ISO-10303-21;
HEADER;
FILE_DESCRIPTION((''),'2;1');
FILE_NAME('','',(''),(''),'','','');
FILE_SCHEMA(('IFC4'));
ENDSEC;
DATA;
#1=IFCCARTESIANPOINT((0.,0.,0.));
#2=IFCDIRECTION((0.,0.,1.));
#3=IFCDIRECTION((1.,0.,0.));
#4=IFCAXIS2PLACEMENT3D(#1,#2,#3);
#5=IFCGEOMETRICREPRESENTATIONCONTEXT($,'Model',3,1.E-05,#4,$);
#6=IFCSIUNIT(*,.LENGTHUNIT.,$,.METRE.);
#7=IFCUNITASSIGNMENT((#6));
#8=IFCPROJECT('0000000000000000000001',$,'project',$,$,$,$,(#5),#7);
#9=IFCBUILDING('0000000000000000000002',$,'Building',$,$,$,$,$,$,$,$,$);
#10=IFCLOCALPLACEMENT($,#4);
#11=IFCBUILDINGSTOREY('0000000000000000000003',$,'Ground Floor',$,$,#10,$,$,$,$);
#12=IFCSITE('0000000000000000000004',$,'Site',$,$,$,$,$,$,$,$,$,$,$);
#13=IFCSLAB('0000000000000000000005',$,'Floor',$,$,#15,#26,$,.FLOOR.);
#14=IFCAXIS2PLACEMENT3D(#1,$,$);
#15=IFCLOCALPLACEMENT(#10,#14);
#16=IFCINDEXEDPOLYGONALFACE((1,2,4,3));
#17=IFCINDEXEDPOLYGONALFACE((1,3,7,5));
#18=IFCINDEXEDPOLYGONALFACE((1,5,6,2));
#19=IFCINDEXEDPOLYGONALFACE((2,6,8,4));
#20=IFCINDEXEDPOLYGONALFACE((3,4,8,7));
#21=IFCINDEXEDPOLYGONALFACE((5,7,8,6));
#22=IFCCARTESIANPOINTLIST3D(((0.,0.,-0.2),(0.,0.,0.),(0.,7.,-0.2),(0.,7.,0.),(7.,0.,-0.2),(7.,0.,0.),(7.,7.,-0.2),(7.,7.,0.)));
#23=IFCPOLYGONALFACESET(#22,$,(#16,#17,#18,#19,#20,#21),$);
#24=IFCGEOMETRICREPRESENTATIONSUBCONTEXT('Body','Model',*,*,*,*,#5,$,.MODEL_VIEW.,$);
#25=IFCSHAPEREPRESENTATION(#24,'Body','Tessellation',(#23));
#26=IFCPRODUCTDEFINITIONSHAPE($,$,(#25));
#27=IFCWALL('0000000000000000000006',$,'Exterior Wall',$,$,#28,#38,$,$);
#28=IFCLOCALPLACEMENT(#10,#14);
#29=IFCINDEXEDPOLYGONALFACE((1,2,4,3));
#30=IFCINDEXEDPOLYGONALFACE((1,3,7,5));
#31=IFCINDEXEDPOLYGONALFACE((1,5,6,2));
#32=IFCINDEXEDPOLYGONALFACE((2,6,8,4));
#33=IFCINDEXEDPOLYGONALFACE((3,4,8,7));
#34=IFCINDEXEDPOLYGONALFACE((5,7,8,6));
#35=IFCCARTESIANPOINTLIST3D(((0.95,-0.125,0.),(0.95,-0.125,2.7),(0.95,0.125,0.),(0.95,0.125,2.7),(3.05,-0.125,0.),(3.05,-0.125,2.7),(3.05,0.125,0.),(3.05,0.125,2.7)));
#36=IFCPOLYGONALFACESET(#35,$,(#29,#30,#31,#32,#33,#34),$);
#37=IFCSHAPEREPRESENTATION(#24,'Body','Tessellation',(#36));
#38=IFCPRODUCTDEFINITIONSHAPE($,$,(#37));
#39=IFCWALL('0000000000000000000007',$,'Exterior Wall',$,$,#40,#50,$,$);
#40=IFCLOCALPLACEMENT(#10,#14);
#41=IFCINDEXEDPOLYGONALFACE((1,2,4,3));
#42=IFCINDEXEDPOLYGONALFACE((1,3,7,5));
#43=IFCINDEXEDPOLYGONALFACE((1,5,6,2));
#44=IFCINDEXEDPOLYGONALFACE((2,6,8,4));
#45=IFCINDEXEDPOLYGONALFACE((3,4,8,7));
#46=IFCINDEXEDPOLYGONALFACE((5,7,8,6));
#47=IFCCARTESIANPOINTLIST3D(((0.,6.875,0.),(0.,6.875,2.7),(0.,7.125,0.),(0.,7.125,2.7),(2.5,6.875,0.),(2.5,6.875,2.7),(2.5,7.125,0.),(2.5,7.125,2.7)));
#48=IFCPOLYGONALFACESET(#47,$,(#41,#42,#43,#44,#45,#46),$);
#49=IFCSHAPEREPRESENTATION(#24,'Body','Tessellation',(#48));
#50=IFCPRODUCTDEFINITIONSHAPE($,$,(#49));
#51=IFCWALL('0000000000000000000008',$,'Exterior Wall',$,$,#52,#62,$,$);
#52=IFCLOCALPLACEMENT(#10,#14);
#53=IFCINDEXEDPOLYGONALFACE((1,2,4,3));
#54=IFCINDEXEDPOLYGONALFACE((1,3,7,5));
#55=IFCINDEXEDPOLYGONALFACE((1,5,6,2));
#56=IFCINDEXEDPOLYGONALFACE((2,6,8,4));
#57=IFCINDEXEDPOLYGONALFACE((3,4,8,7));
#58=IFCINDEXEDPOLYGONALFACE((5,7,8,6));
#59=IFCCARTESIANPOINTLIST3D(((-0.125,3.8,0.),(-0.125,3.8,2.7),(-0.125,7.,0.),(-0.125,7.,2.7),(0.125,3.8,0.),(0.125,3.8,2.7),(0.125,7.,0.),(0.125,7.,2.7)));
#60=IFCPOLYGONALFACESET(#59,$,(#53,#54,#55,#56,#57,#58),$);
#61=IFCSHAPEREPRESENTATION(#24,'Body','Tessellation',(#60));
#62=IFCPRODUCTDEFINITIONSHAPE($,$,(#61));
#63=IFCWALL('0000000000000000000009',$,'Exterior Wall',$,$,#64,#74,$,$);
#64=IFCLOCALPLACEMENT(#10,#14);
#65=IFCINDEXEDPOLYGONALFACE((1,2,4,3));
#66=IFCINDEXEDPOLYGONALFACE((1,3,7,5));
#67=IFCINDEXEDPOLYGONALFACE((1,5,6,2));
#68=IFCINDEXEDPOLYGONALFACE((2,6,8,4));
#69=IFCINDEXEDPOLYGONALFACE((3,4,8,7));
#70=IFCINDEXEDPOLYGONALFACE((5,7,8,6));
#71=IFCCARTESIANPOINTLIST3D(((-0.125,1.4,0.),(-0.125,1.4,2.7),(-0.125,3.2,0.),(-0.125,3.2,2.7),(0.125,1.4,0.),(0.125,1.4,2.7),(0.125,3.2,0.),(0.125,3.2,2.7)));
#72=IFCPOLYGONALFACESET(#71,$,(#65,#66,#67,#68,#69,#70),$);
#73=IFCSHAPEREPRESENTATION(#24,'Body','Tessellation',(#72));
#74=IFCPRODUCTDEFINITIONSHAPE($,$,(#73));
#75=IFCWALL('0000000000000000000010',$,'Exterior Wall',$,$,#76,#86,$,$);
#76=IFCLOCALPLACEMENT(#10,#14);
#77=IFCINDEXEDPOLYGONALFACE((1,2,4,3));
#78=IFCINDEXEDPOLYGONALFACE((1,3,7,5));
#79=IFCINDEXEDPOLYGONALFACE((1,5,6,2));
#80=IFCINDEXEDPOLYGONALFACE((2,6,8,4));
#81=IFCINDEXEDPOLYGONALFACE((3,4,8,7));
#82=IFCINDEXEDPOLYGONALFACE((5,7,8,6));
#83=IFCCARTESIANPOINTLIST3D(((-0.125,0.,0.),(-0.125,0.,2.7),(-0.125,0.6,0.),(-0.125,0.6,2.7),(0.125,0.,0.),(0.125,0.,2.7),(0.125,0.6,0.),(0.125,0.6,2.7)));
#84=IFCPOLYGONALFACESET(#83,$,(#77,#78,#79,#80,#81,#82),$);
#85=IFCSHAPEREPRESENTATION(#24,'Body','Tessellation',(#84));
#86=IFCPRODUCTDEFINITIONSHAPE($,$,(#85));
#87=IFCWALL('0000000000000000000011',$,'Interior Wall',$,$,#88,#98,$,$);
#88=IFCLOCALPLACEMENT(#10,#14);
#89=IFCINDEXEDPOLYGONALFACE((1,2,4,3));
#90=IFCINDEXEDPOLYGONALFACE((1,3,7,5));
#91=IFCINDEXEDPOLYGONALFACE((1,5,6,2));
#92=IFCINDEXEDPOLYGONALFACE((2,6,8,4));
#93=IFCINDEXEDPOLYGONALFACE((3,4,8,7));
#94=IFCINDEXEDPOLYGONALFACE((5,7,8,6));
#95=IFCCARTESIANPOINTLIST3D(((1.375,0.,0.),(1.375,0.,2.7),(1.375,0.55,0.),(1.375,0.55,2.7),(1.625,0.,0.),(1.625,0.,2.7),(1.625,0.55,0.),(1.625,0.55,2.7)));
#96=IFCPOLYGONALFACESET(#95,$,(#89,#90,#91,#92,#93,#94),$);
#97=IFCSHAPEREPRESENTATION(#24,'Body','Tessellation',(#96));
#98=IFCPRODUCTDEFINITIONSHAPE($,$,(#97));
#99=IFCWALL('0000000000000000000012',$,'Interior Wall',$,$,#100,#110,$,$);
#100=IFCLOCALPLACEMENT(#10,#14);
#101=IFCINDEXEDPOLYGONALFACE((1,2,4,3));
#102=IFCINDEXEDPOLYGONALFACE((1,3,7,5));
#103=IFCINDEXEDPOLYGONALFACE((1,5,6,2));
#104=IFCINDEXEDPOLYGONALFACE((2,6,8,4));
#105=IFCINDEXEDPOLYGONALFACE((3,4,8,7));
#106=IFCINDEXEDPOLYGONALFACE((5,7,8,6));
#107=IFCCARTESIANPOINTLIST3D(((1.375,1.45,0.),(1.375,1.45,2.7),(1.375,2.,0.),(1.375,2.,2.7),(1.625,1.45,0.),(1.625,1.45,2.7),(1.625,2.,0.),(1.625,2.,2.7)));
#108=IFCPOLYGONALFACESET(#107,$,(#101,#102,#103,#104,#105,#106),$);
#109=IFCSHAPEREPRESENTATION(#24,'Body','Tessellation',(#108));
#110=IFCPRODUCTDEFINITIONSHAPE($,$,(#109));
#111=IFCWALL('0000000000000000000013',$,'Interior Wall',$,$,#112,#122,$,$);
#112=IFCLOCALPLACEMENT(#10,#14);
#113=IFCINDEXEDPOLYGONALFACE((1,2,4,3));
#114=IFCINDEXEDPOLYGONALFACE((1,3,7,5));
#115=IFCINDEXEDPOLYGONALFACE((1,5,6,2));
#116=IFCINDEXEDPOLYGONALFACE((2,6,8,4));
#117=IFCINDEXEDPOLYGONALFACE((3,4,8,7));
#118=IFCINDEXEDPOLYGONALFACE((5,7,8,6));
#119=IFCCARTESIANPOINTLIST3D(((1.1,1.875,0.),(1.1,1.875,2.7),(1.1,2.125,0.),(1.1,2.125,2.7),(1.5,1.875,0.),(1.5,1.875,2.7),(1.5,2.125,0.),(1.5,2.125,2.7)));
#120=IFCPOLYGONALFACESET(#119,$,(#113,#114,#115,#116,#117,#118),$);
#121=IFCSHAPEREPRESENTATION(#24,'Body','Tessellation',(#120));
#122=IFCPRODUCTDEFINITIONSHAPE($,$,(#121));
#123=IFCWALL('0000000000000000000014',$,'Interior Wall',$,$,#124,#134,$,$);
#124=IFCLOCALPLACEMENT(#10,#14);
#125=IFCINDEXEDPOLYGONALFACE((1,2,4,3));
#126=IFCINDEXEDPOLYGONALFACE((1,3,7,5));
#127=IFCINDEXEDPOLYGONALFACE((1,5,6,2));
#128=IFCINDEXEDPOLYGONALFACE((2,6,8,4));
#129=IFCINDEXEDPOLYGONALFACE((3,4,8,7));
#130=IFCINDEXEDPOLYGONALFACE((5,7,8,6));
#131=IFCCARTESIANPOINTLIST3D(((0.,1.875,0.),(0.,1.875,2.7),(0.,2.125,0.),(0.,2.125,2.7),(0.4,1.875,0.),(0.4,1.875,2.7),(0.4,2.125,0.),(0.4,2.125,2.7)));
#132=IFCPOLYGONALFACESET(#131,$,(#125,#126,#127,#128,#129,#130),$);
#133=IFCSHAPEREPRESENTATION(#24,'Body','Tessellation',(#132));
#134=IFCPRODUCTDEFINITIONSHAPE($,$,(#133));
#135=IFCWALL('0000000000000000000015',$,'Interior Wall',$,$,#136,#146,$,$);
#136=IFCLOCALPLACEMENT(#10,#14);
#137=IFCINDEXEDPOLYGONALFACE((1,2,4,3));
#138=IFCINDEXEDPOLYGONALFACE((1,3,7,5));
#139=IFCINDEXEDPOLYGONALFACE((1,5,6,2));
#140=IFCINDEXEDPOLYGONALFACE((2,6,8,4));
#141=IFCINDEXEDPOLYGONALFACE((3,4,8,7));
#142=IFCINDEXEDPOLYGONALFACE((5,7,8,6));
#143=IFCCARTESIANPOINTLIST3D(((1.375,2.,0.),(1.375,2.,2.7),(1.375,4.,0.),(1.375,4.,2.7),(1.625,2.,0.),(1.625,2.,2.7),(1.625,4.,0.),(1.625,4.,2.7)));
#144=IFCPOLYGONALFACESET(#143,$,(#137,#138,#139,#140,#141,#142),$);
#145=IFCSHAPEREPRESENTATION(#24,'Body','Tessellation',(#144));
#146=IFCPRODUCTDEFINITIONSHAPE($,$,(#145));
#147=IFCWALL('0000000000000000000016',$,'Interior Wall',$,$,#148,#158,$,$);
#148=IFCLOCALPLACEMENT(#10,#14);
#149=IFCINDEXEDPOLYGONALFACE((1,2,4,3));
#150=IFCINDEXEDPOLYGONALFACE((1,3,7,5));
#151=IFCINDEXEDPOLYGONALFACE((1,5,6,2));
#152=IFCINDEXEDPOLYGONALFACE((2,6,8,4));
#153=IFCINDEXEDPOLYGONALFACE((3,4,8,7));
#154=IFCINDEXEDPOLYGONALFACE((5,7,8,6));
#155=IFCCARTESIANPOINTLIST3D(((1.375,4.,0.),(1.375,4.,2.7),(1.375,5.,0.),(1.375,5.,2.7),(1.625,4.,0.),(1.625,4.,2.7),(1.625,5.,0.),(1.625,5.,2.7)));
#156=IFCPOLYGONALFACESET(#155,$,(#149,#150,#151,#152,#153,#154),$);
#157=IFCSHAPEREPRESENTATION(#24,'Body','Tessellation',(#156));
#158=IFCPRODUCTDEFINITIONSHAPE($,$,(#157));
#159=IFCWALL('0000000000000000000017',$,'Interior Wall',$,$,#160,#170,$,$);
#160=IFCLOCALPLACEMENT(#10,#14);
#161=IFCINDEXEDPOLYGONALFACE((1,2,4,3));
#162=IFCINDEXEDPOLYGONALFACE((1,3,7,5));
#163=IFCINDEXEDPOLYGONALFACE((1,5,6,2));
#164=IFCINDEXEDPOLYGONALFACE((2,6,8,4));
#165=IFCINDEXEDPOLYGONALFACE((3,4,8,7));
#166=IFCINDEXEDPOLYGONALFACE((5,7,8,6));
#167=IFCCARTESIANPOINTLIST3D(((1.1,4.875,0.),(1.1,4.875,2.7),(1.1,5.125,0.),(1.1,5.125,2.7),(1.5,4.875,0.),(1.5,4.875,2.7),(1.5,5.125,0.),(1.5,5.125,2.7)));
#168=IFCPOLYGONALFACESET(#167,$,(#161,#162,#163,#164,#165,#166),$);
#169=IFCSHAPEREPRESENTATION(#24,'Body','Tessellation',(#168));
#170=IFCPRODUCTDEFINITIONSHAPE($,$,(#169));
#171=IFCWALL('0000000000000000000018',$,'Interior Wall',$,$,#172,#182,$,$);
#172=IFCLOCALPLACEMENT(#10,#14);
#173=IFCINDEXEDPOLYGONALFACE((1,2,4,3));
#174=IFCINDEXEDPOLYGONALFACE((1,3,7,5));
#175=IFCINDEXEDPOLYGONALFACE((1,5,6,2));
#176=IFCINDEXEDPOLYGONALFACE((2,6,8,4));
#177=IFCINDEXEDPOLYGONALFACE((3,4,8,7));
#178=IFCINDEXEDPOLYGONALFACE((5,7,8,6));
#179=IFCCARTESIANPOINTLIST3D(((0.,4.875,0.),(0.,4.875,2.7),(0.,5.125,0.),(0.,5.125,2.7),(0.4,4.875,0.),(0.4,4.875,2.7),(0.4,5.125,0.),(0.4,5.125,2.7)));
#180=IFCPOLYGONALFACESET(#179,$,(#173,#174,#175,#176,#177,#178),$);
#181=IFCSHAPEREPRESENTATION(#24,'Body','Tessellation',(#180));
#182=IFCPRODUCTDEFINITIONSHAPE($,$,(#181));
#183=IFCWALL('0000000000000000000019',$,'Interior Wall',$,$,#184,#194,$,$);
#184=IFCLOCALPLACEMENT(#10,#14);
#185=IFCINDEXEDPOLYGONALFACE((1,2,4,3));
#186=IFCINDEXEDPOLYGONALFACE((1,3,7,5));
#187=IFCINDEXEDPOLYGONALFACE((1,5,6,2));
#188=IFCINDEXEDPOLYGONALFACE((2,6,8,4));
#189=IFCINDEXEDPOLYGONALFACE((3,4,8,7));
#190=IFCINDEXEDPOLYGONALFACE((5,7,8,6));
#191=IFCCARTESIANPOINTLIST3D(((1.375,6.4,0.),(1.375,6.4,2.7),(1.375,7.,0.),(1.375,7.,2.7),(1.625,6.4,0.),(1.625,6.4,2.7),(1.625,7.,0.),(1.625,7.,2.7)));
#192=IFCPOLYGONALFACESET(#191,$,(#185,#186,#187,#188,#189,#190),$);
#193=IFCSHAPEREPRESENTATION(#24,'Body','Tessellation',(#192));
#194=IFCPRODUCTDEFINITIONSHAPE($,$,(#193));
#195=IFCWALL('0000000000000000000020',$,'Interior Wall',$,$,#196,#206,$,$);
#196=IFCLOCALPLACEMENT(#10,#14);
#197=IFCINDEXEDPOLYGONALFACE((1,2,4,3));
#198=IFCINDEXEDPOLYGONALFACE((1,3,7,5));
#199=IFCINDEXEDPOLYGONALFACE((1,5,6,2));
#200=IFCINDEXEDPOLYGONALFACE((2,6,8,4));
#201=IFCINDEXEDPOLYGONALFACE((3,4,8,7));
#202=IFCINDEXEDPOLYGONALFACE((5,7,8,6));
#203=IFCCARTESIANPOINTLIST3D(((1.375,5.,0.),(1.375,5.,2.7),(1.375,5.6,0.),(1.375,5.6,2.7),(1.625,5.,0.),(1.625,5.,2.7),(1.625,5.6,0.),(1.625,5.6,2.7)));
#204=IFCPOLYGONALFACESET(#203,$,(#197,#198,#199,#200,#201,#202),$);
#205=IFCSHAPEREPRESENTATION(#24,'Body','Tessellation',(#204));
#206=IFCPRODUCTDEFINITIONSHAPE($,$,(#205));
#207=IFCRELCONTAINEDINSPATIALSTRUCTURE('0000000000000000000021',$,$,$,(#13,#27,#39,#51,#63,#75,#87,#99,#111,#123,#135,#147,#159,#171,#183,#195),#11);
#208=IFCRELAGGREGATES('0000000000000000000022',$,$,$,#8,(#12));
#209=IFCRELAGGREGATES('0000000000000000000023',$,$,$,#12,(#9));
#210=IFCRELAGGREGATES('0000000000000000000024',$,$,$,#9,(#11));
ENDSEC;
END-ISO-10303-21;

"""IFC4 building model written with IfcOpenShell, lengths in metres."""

from ifc_helpers import new_model, si_unit, frame, origin_with_axes, place, context, subcontext, project, spatial, indexed_curve, outline, extrude, element, save


model = new_model("IFC4")

# Units and contexts
model_context = context("Model", 3, precision=1e-05, world=origin_with_axes())
body_context = subcontext(model_context, "Body", "Model", "MODEL_VIEW")
ifc_project = project(units=[si_unit("LENGTHUNIT", "METRE")], contexts=[model_context])

# Site, building, storey
site = spatial("IfcSite", under=ifc_project, Name="Site")
building = spatial("IfcBuilding", under=site, Name="Building")
storey_placement = place(None, origin_with_axes())
storey = spatial("IfcBuildingStorey", under=building, at=storey_placement, Name="Ground Floor")

# Slab
slab_placement = place(storey_placement, frame((0.0, 0.0, -0.2), z_axis=(0.0, 0.0, 1.0), x_axis=(1.0, 0.0, 0.0)))
element("IfcSlab", 1, at=slab_placement, inside=storey, Name="Floor", PredefinedType="FLOOR", context=body_context, shape_type="SweptSolid", body=[
    extrude(outline(indexed_curve([(0.0, 0.0), (7.0, 0.0), (7.0, 7.0), (0.0, 7.0)])), None, (0.0, 0.0, 1.0), 0.2),
])

# Walls
wall_1_placement = place(storey_placement, frame((0.95, 0.0, 0.0), z_axis=(0.0, 0.0, 1.0), x_axis=(1.0, 0.0, 0.0)))
element("IfcWall", 2, at=wall_1_placement, inside=storey, Name="Exterior Wall", context=body_context, shape_type="SweptSolid", body=[
    extrude(outline(indexed_curve([(0.0, 0.0), (0.0, 0.25), (2.1, 0.25), (2.1, 0.0), (0.0, 0.0)], self_intersect=False)), frame((0.0, -0.125, 0.0), z_axis=(0.0, 0.0, 1.0), x_axis=(1.0, 0.0, 0.0)), (0.0, 0.0, 1.0), 2.7),
])
wall_2_placement = place(storey_placement, frame((2.5, 7.0, 0.0), z_axis=(0.0, 0.0, 1.0), x_axis=(-1.0, 0.0, 0.0)))
element("IfcWall", 3, at=wall_2_placement, inside=storey, Name="Exterior Wall", context=body_context, shape_type="SweptSolid", body=[
    extrude(outline(indexed_curve([(0.0, 0.0), (0.0, 0.25), (2.5, 0.25), (2.5, 0.0), (0.0, 0.0)], self_intersect=False)), frame((0.0, -0.125, 0.0), z_axis=(0.0, 0.0, 1.0), x_axis=(1.0, 0.0, 0.0)), (0.0, 0.0, 1.0), 2.7),
])
wall_3_placement = place(storey_placement, frame((0.0, 7.0, 0.0), z_axis=(0.0, 0.0, 1.0), x_axis=(0.0, -1.0, 0.0)))
element("IfcWall", 4, at=wall_3_placement, inside=storey, Name="Exterior Wall", context=body_context, shape_type="SweptSolid", body=[
    extrude(outline(indexed_curve([(0.0, 0.0), (0.0, 0.25), (3.2, 0.25), (3.2, 0.0), (0.0, 0.0)], self_intersect=False)), frame((0.0, -0.125, 0.0), z_axis=(0.0, 0.0, 1.0), x_axis=(1.0, 0.0, 0.0)), (0.0, 0.0, 1.0), 2.7),
])
wall_4_placement = place(storey_placement, frame((0.0, 3.2, 0.0), z_axis=(0.0, 0.0, 1.0), x_axis=(0.0, -1.0, 0.0)))
element("IfcWall", 5, at=wall_4_placement, inside=storey, Name="Exterior Wall", context=body_context, shape_type="SweptSolid", body=[
    extrude(outline(indexed_curve([(0.0, 0.0), (0.0, 0.25), (1.8, 0.25), (1.8, 0.0), (0.0, 0.0)], self_intersect=False)), frame((0.0, -0.125, 0.0), z_axis=(0.0, 0.0, 1.0), x_axis=(1.0, 0.0, 0.0)), (0.0, 0.0, 1.0), 2.7),
])
wall_5_placement = place(storey_placement, frame((0.0, 0.6, 0.0), z_axis=(0.0, 0.0, 1.0), x_axis=(0.0, -1.0, 0.0)))
element("IfcWall", 6, at=wall_5_placement, inside=storey, Name="Exterior Wall", context=body_context, shape_type="SweptSolid", body=[
    extrude(outline(indexed_curve([(0.0, 0.0), (0.0, 0.25), (0.6, 0.25), (0.6, 0.0), (0.0, 0.0)], self_intersect=False)), frame((0.0, -0.125, 0.0), z_axis=(0.0, 0.0, 1.0), x_axis=(1.0, 0.0, 0.0)), (0.0, 0.0, 1.0), 2.7),
])
for number, where, z_axis, x_axis, name in (
    (7, (1.5, 0.0, 0.0), (0.0, 0.0, 1.0), (0.0, 1.0, 0.0), "Interior Wall"),
    (8, (1.5, 1.45, 0.0), (0.0, 0.0, 1.0), (0.0, 1.0, 0.0), "Interior Wall"),
):
    element("IfcWall", number, at=place(storey_placement, frame(where, z_axis=z_axis, x_axis=x_axis)), inside=storey, Name=name, context=body_context, shape_type="SweptSolid", body=[
        extrude(outline(indexed_curve([(0.0, 0.0), (0.0, 0.25), (0.55, 0.25), (0.55, 0.0), (0.0, 0.0)], self_intersect=False)), frame((0.0, -0.125, 0.0), z_axis=(0.0, 0.0, 1.0), x_axis=(1.0, 0.0, 0.0)), (0.0, 0.0, 1.0), 2.7),
    ])
for number, where, z_axis, x_axis, name in (
    (9, (1.5, 2.0, 0.0), (0.0, 0.0, 1.0), (-1.0, 0.0, 0.0), "Interior Wall"),
    (10, (0.4, 2.0, 0.0), (0.0, 0.0, 1.0), (-1.0, 0.0, 0.0), "Interior Wall"),
):
    element("IfcWall", number, at=place(storey_placement, frame(where, z_axis=z_axis, x_axis=x_axis)), inside=storey, Name=name, context=body_context, shape_type="SweptSolid", body=[
        extrude(outline(indexed_curve([(0.0, 0.0), (0.0, 0.25), (0.4, 0.25), (0.4, 0.0), (0.0, 0.0)], self_intersect=False)), frame((0.0, -0.125, 0.0), z_axis=(0.0, 0.0, 1.0), x_axis=(1.0, 0.0, 0.0)), (0.0, 0.0, 1.0), 2.7),
    ])
wall_6_placement = place(storey_placement, frame((1.5, 4.0, 0.0), z_axis=(0.0, 0.0, 1.0), x_axis=(0.0, -1.0, 0.0)))
element("IfcWall", 11, at=wall_6_placement, inside=storey, Name="Interior Wall", context=body_context, shape_type="SweptSolid", body=[
    extrude(outline(indexed_curve([(0.0, 0.0), (0.0, 0.25), (2.0, 0.25), (2.0, 0.0), (0.0, 0.0)], self_intersect=False)), frame((0.0, -0.125, 0.0), z_axis=(0.0, 0.0, 1.0), x_axis=(1.0, 0.0, 0.0)), (0.0, 0.0, 1.0), 2.7),
])
wall_7_placement = place(storey_placement, frame((1.5, 4.0, 0.0), z_axis=(0.0, 0.0, 1.0), x_axis=(0.0, 1.0, 0.0)))
element("IfcWall", 12, at=wall_7_placement, inside=storey, Name="Interior Wall", context=body_context, shape_type="SweptSolid", body=[
    extrude(outline(indexed_curve([(0.0, 0.0), (0.0, 0.25), (1.0, 0.25), (1.0, 0.0), (0.0, 0.0)], self_intersect=False)), frame((0.0, -0.125, 0.0), z_axis=(0.0, 0.0, 1.0), x_axis=(1.0, 0.0, 0.0)), (0.0, 0.0, 1.0), 2.7),
])
for number, where, z_axis, x_axis, name in (
    (13, (1.5, 5.0, 0.0), (0.0, 0.0, 1.0), (-1.0, 0.0, 0.0), "Interior Wall"),
    (14, (0.4, 5.0, 0.0), (0.0, 0.0, 1.0), (-1.0, 0.0, 0.0), "Interior Wall"),
):
    element("IfcWall", number, at=place(storey_placement, frame(where, z_axis=z_axis, x_axis=x_axis)), inside=storey, Name=name, context=body_context, shape_type="SweptSolid", body=[
        extrude(outline(indexed_curve([(0.0, 0.0), (0.0, 0.25), (0.4, 0.25), (0.4, 0.0), (0.0, 0.0)], self_intersect=False)), frame((0.0, -0.125, 0.0), z_axis=(0.0, 0.0, 1.0), x_axis=(1.0, 0.0, 0.0)), (0.0, 0.0, 1.0), 2.7),
    ])
for number, where, z_axis, x_axis, name in (
    (15, (1.5, 7.0, 0.0), (0.0, 0.0, 1.0), (0.0, -1.0, 0.0), "Interior Wall"),
    (16, (1.5, 5.6, 0.0), (0.0, 0.0, 1.0), (0.0, -1.0, 0.0), "Interior Wall"),
):
    element("IfcWall", number, at=place(storey_placement, frame(where, z_axis=z_axis, x_axis=x_axis)), inside=storey, Name=name, context=body_context, shape_type="SweptSolid", body=[
        extrude(outline(indexed_curve([(0.0, 0.0), (0.0, 0.25), (0.6, 0.25), (0.6, 0.0), (0.0, 0.0)], self_intersect=False)), frame((0.0, -0.125, 0.0), z_axis=(0.0, 0.0, 1.0), x_axis=(1.0, 0.0, 0.0)), (0.0, 0.0, 1.0), 2.7),
    ])

save(model, "model.ifc")
